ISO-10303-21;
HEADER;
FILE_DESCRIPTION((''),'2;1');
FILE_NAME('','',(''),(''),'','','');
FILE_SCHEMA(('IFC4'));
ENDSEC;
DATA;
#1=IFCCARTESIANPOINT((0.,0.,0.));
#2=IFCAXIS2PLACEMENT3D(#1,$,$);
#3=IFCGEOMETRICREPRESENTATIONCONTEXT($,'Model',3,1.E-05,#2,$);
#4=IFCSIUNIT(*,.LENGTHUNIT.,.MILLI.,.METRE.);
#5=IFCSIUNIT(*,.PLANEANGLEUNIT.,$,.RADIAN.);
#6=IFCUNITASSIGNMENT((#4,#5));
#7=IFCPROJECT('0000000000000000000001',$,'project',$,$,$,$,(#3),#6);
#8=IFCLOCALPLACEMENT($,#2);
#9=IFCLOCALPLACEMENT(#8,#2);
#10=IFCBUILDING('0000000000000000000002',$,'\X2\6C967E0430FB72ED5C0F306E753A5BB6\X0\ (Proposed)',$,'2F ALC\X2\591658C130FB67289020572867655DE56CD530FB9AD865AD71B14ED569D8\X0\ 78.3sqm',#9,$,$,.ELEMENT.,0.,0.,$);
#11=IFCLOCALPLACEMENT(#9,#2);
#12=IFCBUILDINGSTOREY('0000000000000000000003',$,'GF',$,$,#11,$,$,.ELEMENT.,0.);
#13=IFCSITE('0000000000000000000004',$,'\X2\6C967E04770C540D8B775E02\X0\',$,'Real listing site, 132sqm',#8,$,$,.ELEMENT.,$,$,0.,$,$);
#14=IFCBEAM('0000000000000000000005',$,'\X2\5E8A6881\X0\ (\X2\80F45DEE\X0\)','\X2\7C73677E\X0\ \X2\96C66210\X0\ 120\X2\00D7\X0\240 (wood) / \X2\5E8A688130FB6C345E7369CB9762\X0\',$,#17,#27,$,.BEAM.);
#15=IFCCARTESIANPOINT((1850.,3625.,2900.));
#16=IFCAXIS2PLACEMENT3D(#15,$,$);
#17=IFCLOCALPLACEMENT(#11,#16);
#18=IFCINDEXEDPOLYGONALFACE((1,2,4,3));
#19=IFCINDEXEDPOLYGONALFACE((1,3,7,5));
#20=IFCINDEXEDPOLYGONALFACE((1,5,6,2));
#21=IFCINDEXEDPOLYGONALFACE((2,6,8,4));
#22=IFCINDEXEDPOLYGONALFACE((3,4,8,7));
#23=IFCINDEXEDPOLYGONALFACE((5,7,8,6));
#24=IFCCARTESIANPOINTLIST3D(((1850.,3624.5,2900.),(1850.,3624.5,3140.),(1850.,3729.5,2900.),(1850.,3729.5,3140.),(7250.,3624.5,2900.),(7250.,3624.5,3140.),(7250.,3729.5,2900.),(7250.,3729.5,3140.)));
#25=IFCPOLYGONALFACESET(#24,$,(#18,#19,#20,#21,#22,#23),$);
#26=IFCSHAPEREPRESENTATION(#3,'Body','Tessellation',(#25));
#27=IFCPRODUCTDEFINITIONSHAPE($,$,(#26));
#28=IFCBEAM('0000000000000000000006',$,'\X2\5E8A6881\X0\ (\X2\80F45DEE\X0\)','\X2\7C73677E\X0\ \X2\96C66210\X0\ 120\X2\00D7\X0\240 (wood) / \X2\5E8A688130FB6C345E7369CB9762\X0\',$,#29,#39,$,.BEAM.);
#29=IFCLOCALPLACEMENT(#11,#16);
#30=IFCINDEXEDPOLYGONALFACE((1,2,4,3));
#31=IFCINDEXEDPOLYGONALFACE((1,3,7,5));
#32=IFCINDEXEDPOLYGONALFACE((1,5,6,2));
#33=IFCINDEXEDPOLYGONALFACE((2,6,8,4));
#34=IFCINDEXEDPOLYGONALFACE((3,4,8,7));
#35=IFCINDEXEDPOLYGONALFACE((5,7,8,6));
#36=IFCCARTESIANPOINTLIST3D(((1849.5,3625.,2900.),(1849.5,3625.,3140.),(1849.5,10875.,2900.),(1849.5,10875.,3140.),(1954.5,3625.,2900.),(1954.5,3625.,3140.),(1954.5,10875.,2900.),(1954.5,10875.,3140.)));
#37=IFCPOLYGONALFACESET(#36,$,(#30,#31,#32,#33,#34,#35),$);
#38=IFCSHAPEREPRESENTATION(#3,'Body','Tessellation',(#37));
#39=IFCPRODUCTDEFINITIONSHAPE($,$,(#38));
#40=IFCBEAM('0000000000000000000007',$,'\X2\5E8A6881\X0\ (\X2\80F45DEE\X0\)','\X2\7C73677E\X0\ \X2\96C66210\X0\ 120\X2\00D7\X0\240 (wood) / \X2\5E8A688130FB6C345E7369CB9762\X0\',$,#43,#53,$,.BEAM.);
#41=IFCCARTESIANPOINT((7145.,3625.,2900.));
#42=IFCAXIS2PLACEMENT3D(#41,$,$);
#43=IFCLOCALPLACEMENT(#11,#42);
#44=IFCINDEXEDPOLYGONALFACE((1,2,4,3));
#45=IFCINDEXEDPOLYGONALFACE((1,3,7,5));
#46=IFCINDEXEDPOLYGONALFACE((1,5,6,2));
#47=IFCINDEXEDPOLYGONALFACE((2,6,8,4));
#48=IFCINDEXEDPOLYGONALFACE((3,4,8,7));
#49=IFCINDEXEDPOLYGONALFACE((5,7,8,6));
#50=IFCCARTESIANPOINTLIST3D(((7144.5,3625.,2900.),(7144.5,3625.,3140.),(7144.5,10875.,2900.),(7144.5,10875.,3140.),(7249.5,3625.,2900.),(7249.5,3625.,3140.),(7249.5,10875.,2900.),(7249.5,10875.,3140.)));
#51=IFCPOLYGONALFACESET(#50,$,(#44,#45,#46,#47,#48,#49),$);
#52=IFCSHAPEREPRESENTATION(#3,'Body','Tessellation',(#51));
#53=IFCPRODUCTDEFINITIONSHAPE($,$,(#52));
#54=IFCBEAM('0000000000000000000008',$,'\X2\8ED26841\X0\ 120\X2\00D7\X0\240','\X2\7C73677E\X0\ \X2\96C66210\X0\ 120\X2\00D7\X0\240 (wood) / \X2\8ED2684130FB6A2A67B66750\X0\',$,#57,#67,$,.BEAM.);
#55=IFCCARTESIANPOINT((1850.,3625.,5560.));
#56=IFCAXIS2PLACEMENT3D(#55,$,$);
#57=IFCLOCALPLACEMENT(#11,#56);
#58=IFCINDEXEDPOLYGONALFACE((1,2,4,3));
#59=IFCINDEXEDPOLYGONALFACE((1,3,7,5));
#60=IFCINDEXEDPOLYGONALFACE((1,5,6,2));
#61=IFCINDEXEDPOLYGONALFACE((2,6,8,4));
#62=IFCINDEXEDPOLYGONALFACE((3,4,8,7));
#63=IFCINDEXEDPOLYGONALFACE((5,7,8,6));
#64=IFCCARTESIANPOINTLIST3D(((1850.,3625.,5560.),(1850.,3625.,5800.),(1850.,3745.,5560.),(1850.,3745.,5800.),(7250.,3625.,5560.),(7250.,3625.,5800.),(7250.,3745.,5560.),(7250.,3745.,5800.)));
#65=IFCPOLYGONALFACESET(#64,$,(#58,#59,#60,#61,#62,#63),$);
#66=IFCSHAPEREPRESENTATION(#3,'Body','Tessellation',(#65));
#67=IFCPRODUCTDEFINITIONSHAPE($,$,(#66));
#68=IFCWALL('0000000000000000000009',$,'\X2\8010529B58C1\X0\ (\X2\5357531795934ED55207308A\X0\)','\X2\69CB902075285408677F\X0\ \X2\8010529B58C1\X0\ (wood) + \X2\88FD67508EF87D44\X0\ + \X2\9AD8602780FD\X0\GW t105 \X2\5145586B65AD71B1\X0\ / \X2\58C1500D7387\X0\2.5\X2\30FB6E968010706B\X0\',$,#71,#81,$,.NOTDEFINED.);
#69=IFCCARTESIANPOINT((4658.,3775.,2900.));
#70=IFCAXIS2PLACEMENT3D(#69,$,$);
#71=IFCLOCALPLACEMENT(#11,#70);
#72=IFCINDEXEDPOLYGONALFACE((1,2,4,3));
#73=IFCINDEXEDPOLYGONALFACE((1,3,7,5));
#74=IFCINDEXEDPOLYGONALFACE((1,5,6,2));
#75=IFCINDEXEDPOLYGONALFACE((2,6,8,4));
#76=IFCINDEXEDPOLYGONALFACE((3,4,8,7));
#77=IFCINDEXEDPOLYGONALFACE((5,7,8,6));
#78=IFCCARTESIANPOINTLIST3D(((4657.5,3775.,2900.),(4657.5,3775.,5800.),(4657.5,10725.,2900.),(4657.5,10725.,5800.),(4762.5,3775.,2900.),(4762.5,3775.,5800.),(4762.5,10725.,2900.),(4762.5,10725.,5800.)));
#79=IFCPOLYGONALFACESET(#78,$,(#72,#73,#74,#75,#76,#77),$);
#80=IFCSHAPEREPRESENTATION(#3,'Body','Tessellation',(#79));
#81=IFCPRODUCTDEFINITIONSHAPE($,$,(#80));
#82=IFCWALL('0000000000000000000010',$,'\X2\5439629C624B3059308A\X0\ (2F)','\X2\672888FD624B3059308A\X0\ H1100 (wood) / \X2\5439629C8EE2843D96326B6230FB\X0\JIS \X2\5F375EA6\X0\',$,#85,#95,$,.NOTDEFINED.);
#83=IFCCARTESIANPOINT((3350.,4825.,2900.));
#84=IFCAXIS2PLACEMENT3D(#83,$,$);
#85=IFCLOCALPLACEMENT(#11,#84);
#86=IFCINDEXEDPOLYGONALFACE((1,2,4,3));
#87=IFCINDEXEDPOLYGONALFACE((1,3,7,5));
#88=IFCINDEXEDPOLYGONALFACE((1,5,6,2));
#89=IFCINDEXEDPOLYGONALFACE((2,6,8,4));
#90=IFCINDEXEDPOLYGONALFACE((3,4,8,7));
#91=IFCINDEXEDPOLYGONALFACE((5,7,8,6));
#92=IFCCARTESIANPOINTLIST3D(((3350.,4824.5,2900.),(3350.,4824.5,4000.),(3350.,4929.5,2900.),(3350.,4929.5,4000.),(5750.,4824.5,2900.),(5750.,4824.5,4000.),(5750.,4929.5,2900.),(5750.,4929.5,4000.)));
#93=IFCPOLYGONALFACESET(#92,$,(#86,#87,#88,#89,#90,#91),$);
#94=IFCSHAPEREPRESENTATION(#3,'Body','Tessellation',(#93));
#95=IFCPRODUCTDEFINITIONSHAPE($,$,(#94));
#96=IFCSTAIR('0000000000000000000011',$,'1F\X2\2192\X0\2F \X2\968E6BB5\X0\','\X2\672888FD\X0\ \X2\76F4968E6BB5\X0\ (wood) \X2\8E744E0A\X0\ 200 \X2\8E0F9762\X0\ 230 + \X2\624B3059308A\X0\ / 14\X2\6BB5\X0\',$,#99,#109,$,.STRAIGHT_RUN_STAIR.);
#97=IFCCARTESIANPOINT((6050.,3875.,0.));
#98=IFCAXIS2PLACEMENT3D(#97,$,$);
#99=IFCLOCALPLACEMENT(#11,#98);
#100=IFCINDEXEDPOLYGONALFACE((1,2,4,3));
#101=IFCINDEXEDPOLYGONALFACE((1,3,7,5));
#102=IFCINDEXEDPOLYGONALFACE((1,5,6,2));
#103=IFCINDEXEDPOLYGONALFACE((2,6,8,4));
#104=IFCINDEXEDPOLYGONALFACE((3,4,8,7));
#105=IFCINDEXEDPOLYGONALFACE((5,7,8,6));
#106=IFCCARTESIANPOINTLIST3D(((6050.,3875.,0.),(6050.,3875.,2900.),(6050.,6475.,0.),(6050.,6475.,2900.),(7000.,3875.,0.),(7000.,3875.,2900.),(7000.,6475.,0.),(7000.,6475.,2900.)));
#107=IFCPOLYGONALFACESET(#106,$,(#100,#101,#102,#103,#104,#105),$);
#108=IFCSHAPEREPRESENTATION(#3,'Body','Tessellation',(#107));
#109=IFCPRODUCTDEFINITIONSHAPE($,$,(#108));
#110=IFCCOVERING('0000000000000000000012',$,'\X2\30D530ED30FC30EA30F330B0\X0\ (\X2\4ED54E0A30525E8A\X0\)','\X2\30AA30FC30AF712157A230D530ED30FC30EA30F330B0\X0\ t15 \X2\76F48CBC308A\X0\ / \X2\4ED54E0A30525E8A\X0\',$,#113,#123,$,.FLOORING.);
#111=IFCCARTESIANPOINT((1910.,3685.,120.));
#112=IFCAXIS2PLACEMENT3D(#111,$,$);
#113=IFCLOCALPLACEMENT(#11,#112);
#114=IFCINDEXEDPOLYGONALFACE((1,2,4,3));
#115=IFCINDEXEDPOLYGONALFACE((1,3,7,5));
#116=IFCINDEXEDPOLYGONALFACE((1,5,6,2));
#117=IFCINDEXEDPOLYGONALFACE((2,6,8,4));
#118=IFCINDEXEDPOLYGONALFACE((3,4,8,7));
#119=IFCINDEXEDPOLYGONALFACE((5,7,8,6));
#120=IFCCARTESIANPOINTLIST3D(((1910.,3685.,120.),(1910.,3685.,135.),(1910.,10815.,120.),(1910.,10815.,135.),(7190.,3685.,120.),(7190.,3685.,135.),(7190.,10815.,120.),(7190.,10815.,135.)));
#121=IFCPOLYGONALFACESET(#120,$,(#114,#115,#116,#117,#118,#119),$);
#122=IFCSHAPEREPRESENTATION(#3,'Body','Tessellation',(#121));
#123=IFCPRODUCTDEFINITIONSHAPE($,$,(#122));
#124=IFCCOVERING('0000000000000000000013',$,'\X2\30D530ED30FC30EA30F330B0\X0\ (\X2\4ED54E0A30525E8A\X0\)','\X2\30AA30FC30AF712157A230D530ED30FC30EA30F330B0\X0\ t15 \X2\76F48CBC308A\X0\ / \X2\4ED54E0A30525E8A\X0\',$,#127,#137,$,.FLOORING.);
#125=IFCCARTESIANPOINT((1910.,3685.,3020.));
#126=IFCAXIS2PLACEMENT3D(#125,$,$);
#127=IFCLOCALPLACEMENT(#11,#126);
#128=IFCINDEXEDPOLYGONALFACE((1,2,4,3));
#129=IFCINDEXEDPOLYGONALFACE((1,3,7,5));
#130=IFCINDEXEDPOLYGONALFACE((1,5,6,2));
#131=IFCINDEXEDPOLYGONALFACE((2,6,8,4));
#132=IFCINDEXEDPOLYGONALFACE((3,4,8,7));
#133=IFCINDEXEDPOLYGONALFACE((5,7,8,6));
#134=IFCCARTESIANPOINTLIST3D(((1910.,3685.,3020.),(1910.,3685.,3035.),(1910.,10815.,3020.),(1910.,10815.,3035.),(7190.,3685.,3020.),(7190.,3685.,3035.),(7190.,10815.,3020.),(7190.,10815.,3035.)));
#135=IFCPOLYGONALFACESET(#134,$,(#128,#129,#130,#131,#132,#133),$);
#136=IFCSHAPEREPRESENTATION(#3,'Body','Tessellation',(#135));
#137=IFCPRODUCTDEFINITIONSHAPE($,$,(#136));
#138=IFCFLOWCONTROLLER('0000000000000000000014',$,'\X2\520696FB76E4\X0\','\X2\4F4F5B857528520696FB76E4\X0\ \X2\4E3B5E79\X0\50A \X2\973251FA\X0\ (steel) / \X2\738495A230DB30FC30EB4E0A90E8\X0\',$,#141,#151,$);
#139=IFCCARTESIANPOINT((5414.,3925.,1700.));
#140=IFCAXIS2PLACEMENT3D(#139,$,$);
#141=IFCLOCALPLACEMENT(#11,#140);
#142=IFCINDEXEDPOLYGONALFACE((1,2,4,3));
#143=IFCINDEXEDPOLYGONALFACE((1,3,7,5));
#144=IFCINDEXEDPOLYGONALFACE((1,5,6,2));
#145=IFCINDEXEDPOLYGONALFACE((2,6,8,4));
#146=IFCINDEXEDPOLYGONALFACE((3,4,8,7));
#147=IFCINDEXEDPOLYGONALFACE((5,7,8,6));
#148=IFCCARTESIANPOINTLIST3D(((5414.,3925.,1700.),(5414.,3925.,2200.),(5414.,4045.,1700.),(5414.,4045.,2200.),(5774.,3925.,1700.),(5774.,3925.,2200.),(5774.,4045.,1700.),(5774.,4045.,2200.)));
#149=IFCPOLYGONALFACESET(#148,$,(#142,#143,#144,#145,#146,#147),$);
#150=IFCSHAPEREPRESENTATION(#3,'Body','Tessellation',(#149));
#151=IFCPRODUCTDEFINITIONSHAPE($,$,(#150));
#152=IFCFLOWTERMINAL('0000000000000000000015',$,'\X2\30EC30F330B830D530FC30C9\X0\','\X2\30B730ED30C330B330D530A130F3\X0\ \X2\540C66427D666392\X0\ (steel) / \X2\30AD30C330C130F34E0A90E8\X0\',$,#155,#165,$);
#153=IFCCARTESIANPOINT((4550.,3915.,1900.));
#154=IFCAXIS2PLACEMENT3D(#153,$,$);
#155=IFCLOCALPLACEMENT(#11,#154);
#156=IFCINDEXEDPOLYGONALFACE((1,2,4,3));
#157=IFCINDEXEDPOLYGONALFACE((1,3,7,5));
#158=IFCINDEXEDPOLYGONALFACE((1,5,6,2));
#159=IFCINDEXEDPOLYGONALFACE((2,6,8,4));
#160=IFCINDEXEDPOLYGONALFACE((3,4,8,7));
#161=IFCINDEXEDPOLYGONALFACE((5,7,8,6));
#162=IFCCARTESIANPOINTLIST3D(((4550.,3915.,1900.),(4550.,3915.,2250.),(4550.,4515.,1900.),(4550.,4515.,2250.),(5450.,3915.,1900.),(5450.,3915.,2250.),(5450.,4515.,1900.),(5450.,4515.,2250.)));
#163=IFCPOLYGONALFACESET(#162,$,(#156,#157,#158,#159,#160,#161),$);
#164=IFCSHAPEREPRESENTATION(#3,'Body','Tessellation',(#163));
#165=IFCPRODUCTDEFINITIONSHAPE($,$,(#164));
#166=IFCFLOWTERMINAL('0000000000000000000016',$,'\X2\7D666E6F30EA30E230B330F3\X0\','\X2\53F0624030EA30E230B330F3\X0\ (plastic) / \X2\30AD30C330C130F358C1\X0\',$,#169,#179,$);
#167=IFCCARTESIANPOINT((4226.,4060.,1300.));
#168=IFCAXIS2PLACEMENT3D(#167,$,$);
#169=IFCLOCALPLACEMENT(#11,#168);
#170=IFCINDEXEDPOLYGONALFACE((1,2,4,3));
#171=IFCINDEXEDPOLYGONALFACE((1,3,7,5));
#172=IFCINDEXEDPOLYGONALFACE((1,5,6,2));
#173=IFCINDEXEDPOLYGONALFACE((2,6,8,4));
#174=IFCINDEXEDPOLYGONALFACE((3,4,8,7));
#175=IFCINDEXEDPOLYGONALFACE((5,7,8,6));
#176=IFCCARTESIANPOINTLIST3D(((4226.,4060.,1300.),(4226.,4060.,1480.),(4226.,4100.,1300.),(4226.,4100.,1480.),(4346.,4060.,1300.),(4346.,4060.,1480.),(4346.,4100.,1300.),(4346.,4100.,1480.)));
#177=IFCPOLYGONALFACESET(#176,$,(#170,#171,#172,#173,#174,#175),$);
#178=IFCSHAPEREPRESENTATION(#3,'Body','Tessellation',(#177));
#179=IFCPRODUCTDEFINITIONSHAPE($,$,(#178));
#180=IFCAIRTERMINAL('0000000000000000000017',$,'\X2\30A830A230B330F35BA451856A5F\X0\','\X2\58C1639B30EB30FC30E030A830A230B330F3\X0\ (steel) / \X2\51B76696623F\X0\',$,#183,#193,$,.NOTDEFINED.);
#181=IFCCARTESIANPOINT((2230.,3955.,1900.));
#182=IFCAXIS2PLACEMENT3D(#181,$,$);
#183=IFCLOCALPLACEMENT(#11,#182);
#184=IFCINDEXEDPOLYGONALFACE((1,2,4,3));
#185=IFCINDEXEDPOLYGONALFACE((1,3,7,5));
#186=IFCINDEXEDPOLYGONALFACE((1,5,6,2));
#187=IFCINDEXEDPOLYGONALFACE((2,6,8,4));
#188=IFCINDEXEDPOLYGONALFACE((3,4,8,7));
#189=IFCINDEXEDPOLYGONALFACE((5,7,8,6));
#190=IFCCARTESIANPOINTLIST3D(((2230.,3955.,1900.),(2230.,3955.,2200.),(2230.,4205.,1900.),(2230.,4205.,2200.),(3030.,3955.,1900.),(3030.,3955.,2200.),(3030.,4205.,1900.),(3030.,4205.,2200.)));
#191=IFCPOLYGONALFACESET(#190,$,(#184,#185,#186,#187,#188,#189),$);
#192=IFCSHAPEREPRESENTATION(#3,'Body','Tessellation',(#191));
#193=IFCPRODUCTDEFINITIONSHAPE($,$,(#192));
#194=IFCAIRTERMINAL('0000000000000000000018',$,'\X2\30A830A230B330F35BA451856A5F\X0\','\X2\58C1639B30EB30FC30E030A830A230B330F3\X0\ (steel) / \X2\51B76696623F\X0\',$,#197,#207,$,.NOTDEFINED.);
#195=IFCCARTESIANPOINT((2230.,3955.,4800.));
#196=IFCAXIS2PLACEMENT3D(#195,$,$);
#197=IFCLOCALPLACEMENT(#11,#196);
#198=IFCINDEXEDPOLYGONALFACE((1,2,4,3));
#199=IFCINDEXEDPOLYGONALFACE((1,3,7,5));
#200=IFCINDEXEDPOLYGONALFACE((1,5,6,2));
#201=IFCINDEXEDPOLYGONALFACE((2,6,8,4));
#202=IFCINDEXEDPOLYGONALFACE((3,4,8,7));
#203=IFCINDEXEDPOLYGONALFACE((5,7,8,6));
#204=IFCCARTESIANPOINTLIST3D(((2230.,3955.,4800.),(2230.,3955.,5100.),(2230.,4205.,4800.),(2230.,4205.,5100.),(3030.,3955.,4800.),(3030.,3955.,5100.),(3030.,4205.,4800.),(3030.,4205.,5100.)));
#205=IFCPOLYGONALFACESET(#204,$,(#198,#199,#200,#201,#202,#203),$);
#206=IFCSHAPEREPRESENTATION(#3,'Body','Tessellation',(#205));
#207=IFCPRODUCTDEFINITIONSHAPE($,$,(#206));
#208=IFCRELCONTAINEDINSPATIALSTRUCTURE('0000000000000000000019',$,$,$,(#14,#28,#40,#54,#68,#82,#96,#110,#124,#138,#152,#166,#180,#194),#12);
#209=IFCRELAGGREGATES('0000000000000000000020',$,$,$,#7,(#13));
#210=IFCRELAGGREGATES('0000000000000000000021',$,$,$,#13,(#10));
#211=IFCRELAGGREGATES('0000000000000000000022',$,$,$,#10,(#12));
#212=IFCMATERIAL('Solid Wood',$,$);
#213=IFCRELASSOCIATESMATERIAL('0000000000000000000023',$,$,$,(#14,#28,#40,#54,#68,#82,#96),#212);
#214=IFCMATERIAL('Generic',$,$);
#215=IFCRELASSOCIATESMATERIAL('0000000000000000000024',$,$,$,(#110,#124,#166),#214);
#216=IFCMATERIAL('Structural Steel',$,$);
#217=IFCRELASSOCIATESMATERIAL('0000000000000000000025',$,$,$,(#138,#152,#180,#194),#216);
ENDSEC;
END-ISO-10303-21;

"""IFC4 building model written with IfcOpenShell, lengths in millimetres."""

from ifc_helpers import new_model, si_unit, frame, frame_2d, origin, place, context, project, spatial, rectangle, extrude, material, element, save


model = new_model("IFC4")

# Units and contexts
model_context = context("Model", 3, precision=1e-05, world=origin())
ifc_project = project(units=[si_unit("LENGTHUNIT", "METRE", prefix="MILLI"), si_unit("PLANEANGLEUNIT", "RADIAN")], contexts=[model_context])

# Site, building, storey
site_placement = place(None, origin())
site = spatial("IfcSite", under=ifc_project, at=site_placement, Name="沖縄県名護市", ObjectType="Real listing site, 132sqm", CompositionType="ELEMENT", RefElevation=0.0)
building_placement = place(site_placement, origin())
building = spatial("IfcBuilding", under=site, at=building_placement, Name="沖縄・狭小の町家 (Proposed)", ObjectType="2F ALC外壁・木造在来工法・高断熱仕様 78.3sqm", CompositionType="ELEMENT", ElevationOfRefHeight=0.0, ElevationOfTerrain=0.0)
storey_placement = place(building_placement, origin())
storey = spatial("IfcBuildingStorey", under=building, at=storey_placement, Name="GF", CompositionType="ELEMENT", Elevation=0.0)

# Shared definitions
ifc_material_1 = material(Name="Solid Wood")

# Beams
beam_1_placement = place(storey_placement, frame((1850.0, 3625.0, 2900.0)))
element("IfcBeam", 1, at=beam_1_placement, inside=storey, material=ifc_material_1, Name="床梁 (胴差)", Description="米松 集成 120×240 (wood) / 床梁・水平構面", PredefinedType="BEAM", context=model_context, shape_type="SweptSolid", body=[
    extrude(rectangle(XDim=5400.0, YDim=105.0, at=frame_2d((2700.0, 52.0))), frame((1850.0, 3625.0, 2900.0)), (0.0, 0.0, 1.0), 240.0),
])
beam_2_placement = place(storey_placement, frame((1850.0, 3625.0, 2900.0)))
element("IfcBeam", 2, at=beam_2_placement, inside=storey, material=ifc_material_1, Name="床梁 (胴差)", Description="米松 集成 120×240 (wood) / 床梁・水平構面", PredefinedType="BEAM", context=model_context, shape_type="SweptSolid", body=[
    extrude(rectangle(XDim=105.0, YDim=7250.0, at=frame_2d((52.0, 3625.0))), frame((1850.0, 3625.0, 2900.0)), (0.0, 0.0, 1.0), 240.0),
])
beam_3_placement = place(storey_placement, frame((7145.0, 3625.0, 2900.0)))
element("IfcBeam", 3, at=beam_3_placement, inside=storey, material=ifc_material_1, Name="床梁 (胴差)", Description="米松 集成 120×240 (wood) / 床梁・水平構面", PredefinedType="BEAM", context=model_context, shape_type="SweptSolid", body=[
    extrude(rectangle(XDim=105.0, YDim=7250.0, at=frame_2d((52.0, 3625.0))), frame((7145.0, 3625.0, 2900.0)), (0.0, 0.0, 1.0), 240.0),
])
beam_4_placement = place(storey_placement, frame((1850.0, 3625.0, 5560.0)))
element("IfcBeam", 4, at=beam_4_placement, inside=storey, material=ifc_material_1, Name="軒桁 120×240", Description="米松 集成 120×240 (wood) / 軒桁・横架材", PredefinedType="BEAM", context=model_context, shape_type="SweptSolid", body=[
    extrude(rectangle(XDim=5400.0, YDim=120.0, at=frame_2d((2700.0, 60.0))), frame((1850.0, 3625.0, 5560.0)), (0.0, 0.0, 1.0), 240.0),
])

# Walls
wall_1_placement = place(storey_placement, frame((4658.0, 3775.0, 2900.0)))
element("IfcWall", 5, at=wall_1_placement, inside=storey, material=ifc_material_1, Name="耐力壁 (南北間仕切り)", Description="構造用合板 耐力壁 (wood) + 製材軸組 + 高性能GW t105 充填断熱 / 壁倍率2.5・準耐火", PredefinedType="NOTDEFINED", context=model_context, shape_type="SweptSolid", body=[
    extrude(rectangle(XDim=105.0, YDim=6950.0, at=frame_2d((52.0, 3475.0))), frame((4658.0, 3775.0, 2900.0)), (0.0, 0.0, 1.0), 2900.0),
])
wall_2_placement = place(storey_placement, frame((3350.0, 4825.0, 2900.0)))
element("IfcWall", 6, at=wall_2_placement, inside=storey, material=ifc_material_1, Name="吹抜手すり (2F)", Description="木製手すり H1100 (wood) / 吹抜転落防止・JIS 強度", PredefinedType="NOTDEFINED", context=model_context, shape_type="SweptSolid", body=[
    extrude(rectangle(XDim=2400.0, YDim=105.0, at=frame_2d((1200.0, 52.0))), frame((3350.0, 4825.0, 2900.0)), (0.0, 0.0, 1.0), 1100.0),
])

# Stair
stair_placement = place(storey_placement, frame((6050.0, 3875.0, 0.0)))
element("IfcStair", 7, at=stair_placement, inside=storey, material=ifc_material_1, Name="1F→2F 階段", Description="木製 直階段 (wood) 蹴上 200 踏面 230 + 手すり / 14段", PredefinedType="STRAIGHT_RUN_STAIR", context=model_context, shape_type="SweptSolid", body=[
    extrude(rectangle(XDim=950.0, YDim=2600.0, at=frame_2d((475.0, 1300.0))), frame((6050.0, 3875.0, 0.0)), (0.0, 0.0, 1.0), 2900.0),
])

# Coverings
ifc_material_2 = material(Name="Generic")
covering_1_placement = place(storey_placement, frame((1910.0, 3685.0, 120.0)))
element("IfcCovering", 8, at=covering_1_placement, inside=storey, material=ifc_material_2, Name="フローリング (仕上げ床)", Description="オーク無垢フローリング t15 直貼り / 仕上げ床", PredefinedType="FLOORING", context=model_context, shape_type="SweptSolid", body=[
    extrude(rectangle(XDim=5280.0, YDim=7130.0, at=frame_2d((2640.0, 3565.0))), frame((1910.0, 3685.0, 120.0)), (0.0, 0.0, 1.0), 15.0),
])
covering_2_placement = place(storey_placement, frame((1910.0, 3685.0, 3020.0)))
element("IfcCovering", 9, at=covering_2_placement, inside=storey, material=ifc_material_2, Name="フローリング (仕上げ床)", Description="オーク無垢フローリング t15 直貼り / 仕上げ床", PredefinedType="FLOORING", context=model_context, shape_type="SweptSolid", body=[
    extrude(rectangle(XDim=5280.0, YDim=7130.0, at=frame_2d((2640.0, 3565.0))), frame((1910.0, 3685.0, 3020.0)), (0.0, 0.0, 1.0), 15.0),
])

# Flow controller
ifc_material_3 = material(Name="Structural Steel")
flow_controller_placement = place(storey_placement, frame((5414.0, 3925.0, 1700.0)))
element("IfcFlowController", 10, at=flow_controller_placement, inside=storey, material=ifc_material_3, Name="分電盤", Description="住宅用分電盤 主幹50A 露出 (steel) / 玄関ホール上部", context=model_context, shape_type="SweptSolid", body=[
    extrude(rectangle(XDim=360.0, YDim=120.0, at=frame_2d((180.0, 60.0))), frame((5414.0, 3925.0, 1700.0)), (0.0, 0.0, 1.0), 500.0),
])

# Flow terminals
flow_terminal_1_placement = place(storey_placement, frame((4550.0, 3915.0, 1900.0)))
element("IfcFlowTerminal", 11, at=flow_terminal_1_placement, inside=storey, material=ifc_material_3, Name="レンジフード", Description="シロッコファン 同時給排 (steel) / キッチン上部", context=model_context, shape_type="SweptSolid", body=[
    extrude(rectangle(XDim=900.0, YDim=600.0, at=frame_2d((450.0, 300.0))), frame((4550.0, 3915.0, 1900.0)), (0.0, 0.0, 1.0), 350.0),
])
flow_terminal_2_placement = place(storey_placement, frame((4226.0, 4060.0, 1300.0)))
element("IfcFlowTerminal", 12, at=flow_terminal_2_placement, inside=storey, material=ifc_material_2, Name="給湯リモコン", Description="台所リモコン (plastic) / キッチン壁", context=model_context, shape_type="SweptSolid", body=[
    extrude(rectangle(XDim=120.0, YDim=40.0, at=frame_2d((60.0, 20.0))), frame((4226.0, 4060.0, 1300.0)), (0.0, 0.0, 1.0), 180.0),
])

# Air terminals
air_terminal_1_placement = place(storey_placement, frame((2230.0, 3955.0, 1900.0)))
element("IfcAirTerminal", 13, at=air_terminal_1_placement, inside=storey, material=ifc_material_3, Name="エアコン室内機", Description="壁掛ルームエアコン (steel) / 冷暖房", PredefinedType="NOTDEFINED", context=model_context, shape_type="SweptSolid", body=[
    extrude(rectangle(XDim=800.0, YDim=250.0, at=frame_2d((400.0, 125.0))), frame((2230.0, 3955.0, 1900.0)), (0.0, 0.0, 1.0), 300.0),
])
air_terminal_2_placement = place(storey_placement, frame((2230.0, 3955.0, 4800.0)))
element("IfcAirTerminal", 14, at=air_terminal_2_placement, inside=storey, material=ifc_material_3, Name="エアコン室内機", Description="壁掛ルームエアコン (steel) / 冷暖房", PredefinedType="NOTDEFINED", context=model_context, shape_type="SweptSolid", body=[
    extrude(rectangle(XDim=800.0, YDim=250.0, at=frame_2d((400.0, 125.0))), frame((2230.0, 3955.0, 4800.0)), (0.0, 0.0, 1.0), 300.0),
])

save(model, "model.ifc")
